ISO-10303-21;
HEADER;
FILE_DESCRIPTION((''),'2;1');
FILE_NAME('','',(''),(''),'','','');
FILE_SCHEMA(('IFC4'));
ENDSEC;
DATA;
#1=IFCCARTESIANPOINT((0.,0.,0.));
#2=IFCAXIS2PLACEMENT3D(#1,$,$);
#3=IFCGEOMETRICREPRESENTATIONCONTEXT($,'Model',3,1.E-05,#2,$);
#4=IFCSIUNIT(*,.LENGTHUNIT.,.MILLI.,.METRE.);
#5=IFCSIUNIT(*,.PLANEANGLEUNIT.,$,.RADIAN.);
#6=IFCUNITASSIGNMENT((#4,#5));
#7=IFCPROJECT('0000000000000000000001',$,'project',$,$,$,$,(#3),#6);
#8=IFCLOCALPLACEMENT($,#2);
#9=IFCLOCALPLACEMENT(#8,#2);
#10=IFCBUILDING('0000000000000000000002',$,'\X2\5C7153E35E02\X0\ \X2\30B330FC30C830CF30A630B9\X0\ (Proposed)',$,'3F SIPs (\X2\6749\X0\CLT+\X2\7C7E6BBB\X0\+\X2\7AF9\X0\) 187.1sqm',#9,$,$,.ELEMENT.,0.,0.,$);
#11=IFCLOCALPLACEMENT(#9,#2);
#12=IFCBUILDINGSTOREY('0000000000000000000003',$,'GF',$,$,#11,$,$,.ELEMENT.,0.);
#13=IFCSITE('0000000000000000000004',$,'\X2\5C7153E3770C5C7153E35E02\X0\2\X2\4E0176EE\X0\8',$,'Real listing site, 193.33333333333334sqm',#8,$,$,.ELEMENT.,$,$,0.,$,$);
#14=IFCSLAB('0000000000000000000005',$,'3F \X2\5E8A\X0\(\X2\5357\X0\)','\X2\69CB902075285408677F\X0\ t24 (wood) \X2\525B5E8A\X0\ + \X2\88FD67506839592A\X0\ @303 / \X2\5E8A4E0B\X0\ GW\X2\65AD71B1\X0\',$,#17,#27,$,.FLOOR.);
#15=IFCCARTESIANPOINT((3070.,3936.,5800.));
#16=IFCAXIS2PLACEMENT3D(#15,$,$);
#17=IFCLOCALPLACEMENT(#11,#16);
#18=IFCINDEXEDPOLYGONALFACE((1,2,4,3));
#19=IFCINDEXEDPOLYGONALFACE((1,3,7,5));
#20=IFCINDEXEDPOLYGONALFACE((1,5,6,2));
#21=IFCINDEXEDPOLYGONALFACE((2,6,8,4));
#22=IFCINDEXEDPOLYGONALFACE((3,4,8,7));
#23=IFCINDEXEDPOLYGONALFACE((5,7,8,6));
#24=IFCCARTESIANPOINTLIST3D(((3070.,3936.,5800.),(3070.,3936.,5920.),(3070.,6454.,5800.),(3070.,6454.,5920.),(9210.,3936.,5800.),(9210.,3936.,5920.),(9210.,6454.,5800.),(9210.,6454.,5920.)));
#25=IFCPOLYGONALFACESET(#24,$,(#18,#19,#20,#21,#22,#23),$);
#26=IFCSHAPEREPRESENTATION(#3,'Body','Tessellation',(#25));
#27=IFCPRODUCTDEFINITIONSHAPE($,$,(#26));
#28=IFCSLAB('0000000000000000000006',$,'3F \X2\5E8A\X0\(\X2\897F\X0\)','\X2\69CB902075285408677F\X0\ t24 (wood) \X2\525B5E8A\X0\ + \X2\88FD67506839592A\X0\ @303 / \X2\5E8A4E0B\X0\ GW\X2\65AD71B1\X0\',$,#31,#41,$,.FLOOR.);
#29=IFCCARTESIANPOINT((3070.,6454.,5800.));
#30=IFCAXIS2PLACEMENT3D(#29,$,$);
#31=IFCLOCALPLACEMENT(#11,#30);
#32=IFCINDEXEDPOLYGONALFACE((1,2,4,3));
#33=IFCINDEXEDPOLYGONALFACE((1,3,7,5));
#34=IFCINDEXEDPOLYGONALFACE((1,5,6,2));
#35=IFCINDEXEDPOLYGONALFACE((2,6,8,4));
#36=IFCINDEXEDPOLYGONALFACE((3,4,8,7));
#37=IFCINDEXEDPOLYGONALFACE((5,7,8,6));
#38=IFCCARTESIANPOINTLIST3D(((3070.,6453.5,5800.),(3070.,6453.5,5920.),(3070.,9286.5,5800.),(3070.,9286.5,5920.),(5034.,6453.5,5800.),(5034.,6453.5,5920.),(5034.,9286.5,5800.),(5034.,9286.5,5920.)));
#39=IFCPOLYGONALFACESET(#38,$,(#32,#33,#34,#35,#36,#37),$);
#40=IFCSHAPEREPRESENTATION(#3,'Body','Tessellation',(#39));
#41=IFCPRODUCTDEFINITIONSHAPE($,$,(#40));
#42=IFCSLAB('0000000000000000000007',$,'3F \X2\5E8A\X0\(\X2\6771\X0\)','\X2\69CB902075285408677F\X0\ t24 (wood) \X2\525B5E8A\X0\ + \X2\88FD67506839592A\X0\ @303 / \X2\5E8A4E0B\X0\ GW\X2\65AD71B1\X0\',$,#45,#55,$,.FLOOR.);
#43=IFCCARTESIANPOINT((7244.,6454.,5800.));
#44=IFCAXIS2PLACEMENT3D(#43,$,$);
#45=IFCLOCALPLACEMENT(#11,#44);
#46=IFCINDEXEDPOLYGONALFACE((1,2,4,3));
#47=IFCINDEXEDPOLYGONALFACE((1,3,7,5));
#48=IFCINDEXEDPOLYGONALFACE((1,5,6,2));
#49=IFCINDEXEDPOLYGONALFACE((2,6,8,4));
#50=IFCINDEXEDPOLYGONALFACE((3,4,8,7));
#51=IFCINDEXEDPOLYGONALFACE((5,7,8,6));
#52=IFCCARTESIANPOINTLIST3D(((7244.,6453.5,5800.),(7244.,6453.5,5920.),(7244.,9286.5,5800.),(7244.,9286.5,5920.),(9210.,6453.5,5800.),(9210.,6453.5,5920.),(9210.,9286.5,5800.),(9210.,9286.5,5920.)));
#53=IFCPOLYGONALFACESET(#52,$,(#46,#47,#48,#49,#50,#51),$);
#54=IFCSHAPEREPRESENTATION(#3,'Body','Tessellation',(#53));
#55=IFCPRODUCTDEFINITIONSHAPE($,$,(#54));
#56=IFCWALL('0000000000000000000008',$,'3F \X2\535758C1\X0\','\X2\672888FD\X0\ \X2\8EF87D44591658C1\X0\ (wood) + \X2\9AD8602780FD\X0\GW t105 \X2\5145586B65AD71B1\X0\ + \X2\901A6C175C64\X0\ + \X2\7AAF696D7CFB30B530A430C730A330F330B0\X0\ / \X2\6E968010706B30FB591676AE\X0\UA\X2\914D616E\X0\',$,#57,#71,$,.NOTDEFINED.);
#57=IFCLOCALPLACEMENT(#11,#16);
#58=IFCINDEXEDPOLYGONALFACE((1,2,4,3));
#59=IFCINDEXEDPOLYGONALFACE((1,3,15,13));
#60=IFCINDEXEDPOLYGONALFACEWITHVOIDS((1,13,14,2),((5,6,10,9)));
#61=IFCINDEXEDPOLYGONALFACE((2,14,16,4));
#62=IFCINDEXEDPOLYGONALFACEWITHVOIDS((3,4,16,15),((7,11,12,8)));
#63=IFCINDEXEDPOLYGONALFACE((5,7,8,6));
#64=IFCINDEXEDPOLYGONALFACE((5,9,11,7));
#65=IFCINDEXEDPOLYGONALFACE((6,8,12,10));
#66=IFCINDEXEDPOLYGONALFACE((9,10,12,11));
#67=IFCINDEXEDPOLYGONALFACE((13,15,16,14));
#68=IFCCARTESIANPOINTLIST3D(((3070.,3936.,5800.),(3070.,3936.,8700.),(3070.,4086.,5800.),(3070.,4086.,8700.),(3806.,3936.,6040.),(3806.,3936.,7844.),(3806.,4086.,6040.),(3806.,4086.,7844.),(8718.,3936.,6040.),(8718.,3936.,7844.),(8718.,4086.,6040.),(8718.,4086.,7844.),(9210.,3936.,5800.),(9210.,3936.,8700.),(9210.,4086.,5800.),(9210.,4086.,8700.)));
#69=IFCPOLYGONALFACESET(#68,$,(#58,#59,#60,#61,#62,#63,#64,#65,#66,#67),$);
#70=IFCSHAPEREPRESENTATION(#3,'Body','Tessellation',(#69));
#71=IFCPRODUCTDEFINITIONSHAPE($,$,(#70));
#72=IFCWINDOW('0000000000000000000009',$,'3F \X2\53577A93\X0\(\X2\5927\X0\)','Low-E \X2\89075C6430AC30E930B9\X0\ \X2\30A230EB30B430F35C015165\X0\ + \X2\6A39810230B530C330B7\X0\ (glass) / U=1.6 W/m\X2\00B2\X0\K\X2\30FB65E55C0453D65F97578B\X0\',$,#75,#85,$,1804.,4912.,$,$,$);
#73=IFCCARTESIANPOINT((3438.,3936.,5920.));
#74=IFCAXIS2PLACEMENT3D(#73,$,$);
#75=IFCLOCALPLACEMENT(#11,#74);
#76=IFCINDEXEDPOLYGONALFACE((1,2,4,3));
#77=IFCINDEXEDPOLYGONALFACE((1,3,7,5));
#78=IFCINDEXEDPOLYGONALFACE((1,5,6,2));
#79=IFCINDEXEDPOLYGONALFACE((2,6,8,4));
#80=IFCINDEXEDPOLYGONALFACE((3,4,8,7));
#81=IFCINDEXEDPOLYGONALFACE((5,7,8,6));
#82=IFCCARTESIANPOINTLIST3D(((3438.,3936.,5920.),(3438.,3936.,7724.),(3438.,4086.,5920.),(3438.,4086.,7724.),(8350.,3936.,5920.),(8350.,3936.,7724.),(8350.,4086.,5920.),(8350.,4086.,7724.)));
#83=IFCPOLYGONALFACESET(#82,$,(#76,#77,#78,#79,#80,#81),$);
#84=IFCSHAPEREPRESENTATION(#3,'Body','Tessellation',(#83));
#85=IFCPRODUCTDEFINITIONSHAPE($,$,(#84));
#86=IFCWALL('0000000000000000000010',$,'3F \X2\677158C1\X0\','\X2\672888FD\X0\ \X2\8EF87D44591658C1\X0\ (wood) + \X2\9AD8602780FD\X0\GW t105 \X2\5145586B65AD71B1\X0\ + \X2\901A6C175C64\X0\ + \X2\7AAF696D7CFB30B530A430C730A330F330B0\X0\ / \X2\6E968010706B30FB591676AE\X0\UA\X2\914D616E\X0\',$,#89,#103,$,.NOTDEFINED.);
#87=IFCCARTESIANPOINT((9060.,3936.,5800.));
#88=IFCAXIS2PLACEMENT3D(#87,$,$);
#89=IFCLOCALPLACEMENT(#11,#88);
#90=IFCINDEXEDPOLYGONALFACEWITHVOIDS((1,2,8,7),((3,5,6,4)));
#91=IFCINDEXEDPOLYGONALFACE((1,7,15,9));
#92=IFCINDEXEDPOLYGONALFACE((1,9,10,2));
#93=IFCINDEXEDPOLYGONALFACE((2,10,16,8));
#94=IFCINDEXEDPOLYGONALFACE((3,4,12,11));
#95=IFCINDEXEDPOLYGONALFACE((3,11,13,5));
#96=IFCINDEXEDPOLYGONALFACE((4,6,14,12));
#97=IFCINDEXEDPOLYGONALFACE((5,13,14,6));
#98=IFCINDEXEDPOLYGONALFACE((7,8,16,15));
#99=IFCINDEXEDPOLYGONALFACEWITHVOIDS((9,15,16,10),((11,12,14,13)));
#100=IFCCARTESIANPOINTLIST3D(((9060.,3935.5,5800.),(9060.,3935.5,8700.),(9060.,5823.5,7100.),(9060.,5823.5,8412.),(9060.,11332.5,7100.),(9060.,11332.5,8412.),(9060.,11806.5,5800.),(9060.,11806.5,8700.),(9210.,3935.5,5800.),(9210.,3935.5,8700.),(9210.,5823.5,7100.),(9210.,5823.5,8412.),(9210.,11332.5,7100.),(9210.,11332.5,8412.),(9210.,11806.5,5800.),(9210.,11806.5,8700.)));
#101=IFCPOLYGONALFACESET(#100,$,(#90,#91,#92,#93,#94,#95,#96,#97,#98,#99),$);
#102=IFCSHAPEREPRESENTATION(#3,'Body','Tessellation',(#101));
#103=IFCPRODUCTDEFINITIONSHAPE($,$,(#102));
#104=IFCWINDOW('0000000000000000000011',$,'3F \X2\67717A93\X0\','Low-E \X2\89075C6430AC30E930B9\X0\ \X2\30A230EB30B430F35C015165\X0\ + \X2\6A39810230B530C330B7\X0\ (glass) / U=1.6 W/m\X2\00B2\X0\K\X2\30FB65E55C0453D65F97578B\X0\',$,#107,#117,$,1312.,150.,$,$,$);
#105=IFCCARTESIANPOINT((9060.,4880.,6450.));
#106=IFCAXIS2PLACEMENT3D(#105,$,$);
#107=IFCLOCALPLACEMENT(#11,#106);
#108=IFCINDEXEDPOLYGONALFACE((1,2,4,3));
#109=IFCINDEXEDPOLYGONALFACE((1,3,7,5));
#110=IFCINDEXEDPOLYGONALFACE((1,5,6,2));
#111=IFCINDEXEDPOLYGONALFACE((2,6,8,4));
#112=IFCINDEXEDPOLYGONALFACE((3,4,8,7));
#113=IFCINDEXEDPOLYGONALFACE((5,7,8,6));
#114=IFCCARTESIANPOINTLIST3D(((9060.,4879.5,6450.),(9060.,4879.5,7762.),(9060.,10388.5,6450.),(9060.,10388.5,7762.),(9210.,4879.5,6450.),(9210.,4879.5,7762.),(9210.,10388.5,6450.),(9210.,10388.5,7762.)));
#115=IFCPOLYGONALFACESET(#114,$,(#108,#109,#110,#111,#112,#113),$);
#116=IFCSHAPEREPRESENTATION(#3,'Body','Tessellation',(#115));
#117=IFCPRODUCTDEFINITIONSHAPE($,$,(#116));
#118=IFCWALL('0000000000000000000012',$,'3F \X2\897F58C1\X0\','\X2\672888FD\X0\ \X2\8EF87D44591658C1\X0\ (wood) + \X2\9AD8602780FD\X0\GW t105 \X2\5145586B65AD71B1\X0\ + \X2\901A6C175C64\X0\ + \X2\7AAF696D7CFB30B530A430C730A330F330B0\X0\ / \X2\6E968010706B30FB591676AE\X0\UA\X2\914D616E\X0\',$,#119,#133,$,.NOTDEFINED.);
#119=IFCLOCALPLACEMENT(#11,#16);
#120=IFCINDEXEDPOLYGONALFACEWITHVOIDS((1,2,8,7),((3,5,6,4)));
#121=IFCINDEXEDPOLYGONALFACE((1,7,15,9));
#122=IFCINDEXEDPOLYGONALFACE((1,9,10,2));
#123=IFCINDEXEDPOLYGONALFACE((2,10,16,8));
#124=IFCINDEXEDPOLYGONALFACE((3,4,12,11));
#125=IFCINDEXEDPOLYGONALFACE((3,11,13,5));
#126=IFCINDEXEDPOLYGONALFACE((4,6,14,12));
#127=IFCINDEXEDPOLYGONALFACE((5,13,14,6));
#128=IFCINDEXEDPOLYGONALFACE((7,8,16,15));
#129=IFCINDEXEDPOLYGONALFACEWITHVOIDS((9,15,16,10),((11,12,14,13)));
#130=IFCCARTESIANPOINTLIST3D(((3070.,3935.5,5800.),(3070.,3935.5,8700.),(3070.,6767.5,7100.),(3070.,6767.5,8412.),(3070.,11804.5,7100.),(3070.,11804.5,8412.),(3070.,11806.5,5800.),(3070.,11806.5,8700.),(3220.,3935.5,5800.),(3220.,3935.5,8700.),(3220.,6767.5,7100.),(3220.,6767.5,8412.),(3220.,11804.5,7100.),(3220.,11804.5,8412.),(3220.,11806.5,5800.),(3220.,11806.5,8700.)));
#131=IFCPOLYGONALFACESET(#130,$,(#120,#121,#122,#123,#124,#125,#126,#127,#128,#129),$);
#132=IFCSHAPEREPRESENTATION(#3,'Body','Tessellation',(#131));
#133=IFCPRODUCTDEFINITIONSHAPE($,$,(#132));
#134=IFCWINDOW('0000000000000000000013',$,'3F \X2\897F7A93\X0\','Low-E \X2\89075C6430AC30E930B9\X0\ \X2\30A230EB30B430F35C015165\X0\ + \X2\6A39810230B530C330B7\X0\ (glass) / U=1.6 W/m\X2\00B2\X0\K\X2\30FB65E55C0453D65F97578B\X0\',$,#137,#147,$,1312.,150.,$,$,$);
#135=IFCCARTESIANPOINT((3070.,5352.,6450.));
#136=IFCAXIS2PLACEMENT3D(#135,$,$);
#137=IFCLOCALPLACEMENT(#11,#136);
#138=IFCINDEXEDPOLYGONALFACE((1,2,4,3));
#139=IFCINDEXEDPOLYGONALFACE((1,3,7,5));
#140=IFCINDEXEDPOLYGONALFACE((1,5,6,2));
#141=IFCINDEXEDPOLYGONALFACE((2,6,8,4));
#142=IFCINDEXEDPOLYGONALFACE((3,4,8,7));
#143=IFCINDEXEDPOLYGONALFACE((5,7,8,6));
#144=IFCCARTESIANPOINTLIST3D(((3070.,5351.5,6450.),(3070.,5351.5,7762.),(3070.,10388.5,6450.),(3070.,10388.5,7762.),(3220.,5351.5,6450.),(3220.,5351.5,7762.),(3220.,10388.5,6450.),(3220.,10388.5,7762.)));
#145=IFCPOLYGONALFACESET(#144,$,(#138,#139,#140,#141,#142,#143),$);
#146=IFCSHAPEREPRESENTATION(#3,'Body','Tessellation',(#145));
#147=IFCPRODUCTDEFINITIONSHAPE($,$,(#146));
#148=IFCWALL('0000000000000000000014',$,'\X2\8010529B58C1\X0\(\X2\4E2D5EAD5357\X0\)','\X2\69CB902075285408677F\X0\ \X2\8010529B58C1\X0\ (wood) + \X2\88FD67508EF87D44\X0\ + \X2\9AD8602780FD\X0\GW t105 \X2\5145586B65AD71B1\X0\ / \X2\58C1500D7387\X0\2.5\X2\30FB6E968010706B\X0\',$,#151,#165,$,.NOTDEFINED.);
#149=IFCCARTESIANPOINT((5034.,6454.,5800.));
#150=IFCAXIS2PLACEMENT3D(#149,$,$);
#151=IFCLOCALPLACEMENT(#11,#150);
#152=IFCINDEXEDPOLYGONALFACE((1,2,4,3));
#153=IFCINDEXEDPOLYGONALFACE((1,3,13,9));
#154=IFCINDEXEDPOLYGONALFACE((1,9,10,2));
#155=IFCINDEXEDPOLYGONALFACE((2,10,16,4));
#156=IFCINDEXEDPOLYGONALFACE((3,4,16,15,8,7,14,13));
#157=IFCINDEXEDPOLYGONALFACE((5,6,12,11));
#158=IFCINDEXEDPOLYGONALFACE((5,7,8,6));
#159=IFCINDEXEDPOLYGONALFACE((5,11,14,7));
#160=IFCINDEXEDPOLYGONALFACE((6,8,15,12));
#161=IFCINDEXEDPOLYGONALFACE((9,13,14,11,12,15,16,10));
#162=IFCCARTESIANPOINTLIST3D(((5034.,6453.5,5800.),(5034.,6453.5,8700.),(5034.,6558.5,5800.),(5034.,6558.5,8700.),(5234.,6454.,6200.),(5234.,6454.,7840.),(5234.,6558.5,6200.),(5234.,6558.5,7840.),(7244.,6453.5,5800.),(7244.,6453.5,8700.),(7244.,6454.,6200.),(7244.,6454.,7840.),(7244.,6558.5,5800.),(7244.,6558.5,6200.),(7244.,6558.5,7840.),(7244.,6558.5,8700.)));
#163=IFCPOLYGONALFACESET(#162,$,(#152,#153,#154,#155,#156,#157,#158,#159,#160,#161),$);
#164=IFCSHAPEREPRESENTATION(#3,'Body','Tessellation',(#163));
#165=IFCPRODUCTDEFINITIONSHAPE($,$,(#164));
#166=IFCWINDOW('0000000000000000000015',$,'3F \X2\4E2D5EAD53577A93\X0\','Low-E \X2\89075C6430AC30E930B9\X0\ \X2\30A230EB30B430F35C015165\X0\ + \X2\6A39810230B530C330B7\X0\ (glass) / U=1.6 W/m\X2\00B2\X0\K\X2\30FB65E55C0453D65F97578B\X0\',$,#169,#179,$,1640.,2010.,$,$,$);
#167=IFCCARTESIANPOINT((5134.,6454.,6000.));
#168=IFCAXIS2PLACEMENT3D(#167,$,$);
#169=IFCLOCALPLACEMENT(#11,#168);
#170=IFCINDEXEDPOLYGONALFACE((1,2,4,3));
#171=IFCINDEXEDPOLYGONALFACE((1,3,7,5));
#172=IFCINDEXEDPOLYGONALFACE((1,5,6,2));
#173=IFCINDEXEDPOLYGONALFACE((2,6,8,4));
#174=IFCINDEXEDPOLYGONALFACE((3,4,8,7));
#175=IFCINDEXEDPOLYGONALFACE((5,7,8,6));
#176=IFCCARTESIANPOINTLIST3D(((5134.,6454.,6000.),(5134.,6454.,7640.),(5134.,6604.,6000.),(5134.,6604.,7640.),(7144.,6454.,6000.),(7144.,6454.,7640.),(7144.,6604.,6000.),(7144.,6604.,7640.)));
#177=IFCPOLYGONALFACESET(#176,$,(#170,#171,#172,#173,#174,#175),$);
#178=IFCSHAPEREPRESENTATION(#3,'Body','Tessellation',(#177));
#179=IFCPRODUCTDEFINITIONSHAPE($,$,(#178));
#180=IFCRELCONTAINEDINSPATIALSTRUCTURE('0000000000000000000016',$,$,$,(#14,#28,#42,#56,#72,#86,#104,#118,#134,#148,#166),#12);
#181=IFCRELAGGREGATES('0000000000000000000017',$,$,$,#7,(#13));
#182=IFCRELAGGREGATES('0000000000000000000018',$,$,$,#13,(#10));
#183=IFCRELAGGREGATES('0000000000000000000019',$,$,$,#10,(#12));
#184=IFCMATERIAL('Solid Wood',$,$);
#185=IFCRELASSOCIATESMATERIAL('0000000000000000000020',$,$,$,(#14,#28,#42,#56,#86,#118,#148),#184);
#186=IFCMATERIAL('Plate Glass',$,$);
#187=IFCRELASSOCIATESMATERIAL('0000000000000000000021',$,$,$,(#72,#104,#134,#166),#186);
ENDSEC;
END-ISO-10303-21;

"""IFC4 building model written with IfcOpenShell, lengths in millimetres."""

from ifc_helpers import new_model, si_unit, frame, frame_2d, origin, place, context, project, spatial, rectangle, extrude, material, element, fill, save


model = new_model("IFC4")

# Units and contexts
model_context = context("Model", 3, precision=1e-05, world=origin())
ifc_project = project(units=[si_unit("LENGTHUNIT", "METRE", prefix="MILLI"), si_unit("PLANEANGLEUNIT", "RADIAN")], contexts=[model_context])

# Site, building, storey
site_placement = place(None, origin())
site = spatial("IfcSite", under=ifc_project, at=site_placement, Name="山口県山口市2丁目8", ObjectType="Real listing site, 193.33333333333334sqm", CompositionType="ELEMENT", RefElevation=0.0)
building_placement = place(site_placement, origin())
building = spatial("IfcBuilding", under=site, at=building_placement, Name="山口市 コートハウス (Proposed)", ObjectType="3F SIPs (杉CLT+籾殻+竹) 187.1sqm", CompositionType="ELEMENT", ElevationOfRefHeight=0.0, ElevationOfTerrain=0.0)
storey_placement = place(building_placement, origin())
storey = spatial("IfcBuildingStorey", under=building, at=storey_placement, Name="GF", CompositionType="ELEMENT", Elevation=0.0)

# Slabs
ifc_material_1 = material(Name="Solid Wood")
slab_1_placement = place(storey_placement, frame((3070.0, 3936.0, 5800.0)))
element("IfcSlab", 1, at=slab_1_placement, inside=storey, material=ifc_material_1, Name="3F 床(南)", Description="構造用合板 t24 (wood) 剛床 + 製材根太 @303 / 床下 GW断熱", PredefinedType="FLOOR", context=model_context, shape_type="SweptSolid", body=[
    extrude(rectangle(XDim=6140.0, YDim=2518.0, at=frame_2d((3070.0, 1259.0))), frame((3070.0, 3936.0, 5800.0)), (0.0, 0.0, 1.0), 120.0),
])
slab_2_placement = place(storey_placement, frame((3070.0, 6454.0, 5800.0)))
element("IfcSlab", 2, at=slab_2_placement, inside=storey, material=ifc_material_1, Name="3F 床(西)", Description="構造用合板 t24 (wood) 剛床 + 製材根太 @303 / 床下 GW断熱", PredefinedType="FLOOR", context=model_context, shape_type="SweptSolid", body=[
    extrude(rectangle(XDim=1964.0, YDim=2833.0, at=frame_2d((982.0, 1416.0))), frame((3070.0, 6454.0, 5800.0)), (0.0, 0.0, 1.0), 120.0),
])
slab_3_placement = place(storey_placement, frame((7244.0, 6454.0, 5800.0)))
element("IfcSlab", 3, at=slab_3_placement, inside=storey, material=ifc_material_1, Name="3F 床(東)", Description="構造用合板 t24 (wood) 剛床 + 製材根太 @303 / 床下 GW断熱", PredefinedType="FLOOR", context=model_context, shape_type="SweptSolid", body=[
    extrude(rectangle(XDim=1966.0, YDim=2833.0, at=frame_2d((983.0, 1416.0))), frame((7244.0, 6454.0, 5800.0)), (0.0, 0.0, 1.0), 120.0),
])

# Walls, openings, windows
wall_1_placement = place(storey_placement, frame((3070.0, 3936.0, 5800.0)))
wall_1 = element("IfcWall", 4, at=wall_1_placement, inside=storey, material=ifc_material_1, Name="3F 南壁", Description="木製 軸組外壁 (wood) + 高性能GW t105 充填断熱 + 通気層 + 窯業系サイディング / 準耐火・外皮UA配慮", PredefinedType="NOTDEFINED", context=model_context, shape_type="SweptSolid", body=[
    extrude(rectangle(XDim=6140.0, YDim=150.0, at=frame_2d((3070.0, 75.0))), frame((3070.0, 3936.0, 5800.0)), (0.0, 0.0, 1.0), 2900.0),
])
opening_1_placement = place(storey_placement, frame((3438.0, 3936.0, 5920.0)))
opening_1 = element("IfcOpeningElement", 5, at=opening_1_placement, cuts=wall_1, PredefinedType="NOTDEFINED", context=model_context, shape_type="SweptSolid", body=[
    extrude(rectangle(XDim=4912.0, YDim=150.0, at=frame_2d((2456.0, 75.0))), frame((3438.0, 3936.0, 5920.0)), (0.0, 0.0, 1.0), 1804.0),
])
ifc_material_2 = material(Name="Plate Glass")
window_1_placement = place(storey_placement, frame((3438.0, 3936.0, 5920.0)))
window_1 = element("IfcWindow", 6, at=window_1_placement, inside=storey, material=ifc_material_2, Name="3F 南窓(大)", Description="Low-E 複層ガラス アルゴン封入 + 樹脂サッシ (glass) / U=1.6 W/m²K・日射取得型", OverallHeight=1804.0, OverallWidth=4912.0, context=model_context, shape_type="SweptSolid", body=[
    extrude(rectangle(XDim=4912.0, YDim=150.0, at=frame_2d((2456.0, 75.0))), frame((3438.0, 3936.0, 5920.0)), (0.0, 0.0, 1.0), 1804.0),
])
fill(opening_1, window_1)
wall_2_placement = place(storey_placement, frame((9060.0, 3936.0, 5800.0)))
wall_2 = element("IfcWall", 7, at=wall_2_placement, inside=storey, material=ifc_material_1, Name="3F 東壁", Description="木製 軸組外壁 (wood) + 高性能GW t105 充填断熱 + 通気層 + 窯業系サイディング / 準耐火・外皮UA配慮", PredefinedType="NOTDEFINED", context=model_context, shape_type="SweptSolid", body=[
    extrude(rectangle(XDim=150.0, YDim=7871.0, at=frame_2d((75.0, 3935.0))), frame((9060.0, 3936.0, 5800.0)), (0.0, 0.0, 1.0), 2900.0),
])
opening_2_placement = place(storey_placement, frame((9060.0, 4880.0, 6450.0)))
opening_2 = element("IfcOpeningElement", 8, at=opening_2_placement, cuts=wall_2, PredefinedType="NOTDEFINED", context=model_context, shape_type="SweptSolid", body=[
    extrude(rectangle(XDim=150.0, YDim=5509.0, at=frame_2d((75.0, 2754.0))), frame((9060.0, 4880.0, 6450.0)), (0.0, 0.0, 1.0), 1312.0),
])
window_2_placement = place(storey_placement, frame((9060.0, 4880.0, 6450.0)))
window_2 = element("IfcWindow", 9, at=window_2_placement, inside=storey, material=ifc_material_2, Name="3F 東窓", Description="Low-E 複層ガラス アルゴン封入 + 樹脂サッシ (glass) / U=1.6 W/m²K・日射取得型", OverallHeight=1312.0, OverallWidth=150.0, context=model_context, shape_type="SweptSolid", body=[
    extrude(rectangle(XDim=150.0, YDim=5509.0, at=frame_2d((75.0, 2754.0))), frame((9060.0, 4880.0, 6450.0)), (0.0, 0.0, 1.0), 1312.0),
])
fill(opening_2, window_2)
wall_3_placement = place(storey_placement, frame((3070.0, 3936.0, 5800.0)))
wall_3 = element("IfcWall", 10, at=wall_3_placement, inside=storey, material=ifc_material_1, Name="3F 西壁", Description="木製 軸組外壁 (wood) + 高性能GW t105 充填断熱 + 通気層 + 窯業系サイディング / 準耐火・外皮UA配慮", PredefinedType="NOTDEFINED", context=model_context, shape_type="SweptSolid", body=[
    extrude(rectangle(XDim=150.0, YDim=7871.0, at=frame_2d((75.0, 3935.0))), frame((3070.0, 3936.0, 5800.0)), (0.0, 0.0, 1.0), 2900.0),
])
opening_3_placement = place(storey_placement, frame((3070.0, 5352.0, 6450.0)))
opening_3 = element("IfcOpeningElement", 11, at=opening_3_placement, cuts=wall_3, PredefinedType="NOTDEFINED", context=model_context, shape_type="SweptSolid", body=[
    extrude(rectangle(XDim=150.0, YDim=5037.0, at=frame_2d((75.0, 2518.0))), frame((3070.0, 5352.0, 6450.0)), (0.0, 0.0, 1.0), 1312.0),
])
window_3_placement = place(storey_placement, frame((3070.0, 5352.0, 6450.0)))
window_3 = element("IfcWindow", 12, at=window_3_placement, inside=storey, material=ifc_material_2, Name="3F 西窓", Description="Low-E 複層ガラス アルゴン封入 + 樹脂サッシ (glass) / U=1.6 W/m²K・日射取得型", OverallHeight=1312.0, OverallWidth=150.0, context=model_context, shape_type="SweptSolid", body=[
    extrude(rectangle(XDim=150.0, YDim=5037.0, at=frame_2d((75.0, 2518.0))), frame((3070.0, 5352.0, 6450.0)), (0.0, 0.0, 1.0), 1312.0),
])
fill(opening_3, window_3)
wall_4_placement = place(storey_placement, frame((5034.0, 6454.0, 5800.0)))
wall_4 = element("IfcWall", 13, at=wall_4_placement, inside=storey, material=ifc_material_1, Name="耐力壁(中庭南)", Description="構造用合板 耐力壁 (wood) + 製材軸組 + 高性能GW t105 充填断熱 / 壁倍率2.5・準耐火", PredefinedType="NOTDEFINED", context=model_context, shape_type="SweptSolid", body=[
    extrude(rectangle(XDim=2210.0, YDim=105.0, at=frame_2d((1105.0, 52.0))), frame((5034.0, 6454.0, 5800.0)), (0.0, 0.0, 1.0), 2900.0),
])
opening_4_placement = place(storey_placement, frame((5134.0, 6454.0, 6000.0)))
opening_4 = element("IfcOpeningElement", 14, at=opening_4_placement, cuts=wall_4, PredefinedType="NOTDEFINED", context=model_context, shape_type="SweptSolid", body=[
    extrude(rectangle(XDim=2010.0, YDim=150.0, at=frame_2d((1005.0, 75.0))), frame((5134.0, 6454.0, 6000.0)), (0.0, 0.0, 1.0), 1640.0),
])
window_4_placement = place(storey_placement, frame((5134.0, 6454.0, 6000.0)))
window_4 = element("IfcWindow", 15, at=window_4_placement, inside=storey, material=ifc_material_2, Name="3F 中庭南窓", Description="Low-E 複層ガラス アルゴン封入 + 樹脂サッシ (glass) / U=1.6 W/m²K・日射取得型", OverallHeight=1640.0, OverallWidth=2010.0, context=model_context, shape_type="SweptSolid", body=[
    extrude(rectangle(XDim=2010.0, YDim=150.0, at=frame_2d((1005.0, 75.0))), frame((5134.0, 6454.0, 6000.0)), (0.0, 0.0, 1.0), 1640.0),
])
fill(opening_4, window_4)

save(model, "model.ifc")
